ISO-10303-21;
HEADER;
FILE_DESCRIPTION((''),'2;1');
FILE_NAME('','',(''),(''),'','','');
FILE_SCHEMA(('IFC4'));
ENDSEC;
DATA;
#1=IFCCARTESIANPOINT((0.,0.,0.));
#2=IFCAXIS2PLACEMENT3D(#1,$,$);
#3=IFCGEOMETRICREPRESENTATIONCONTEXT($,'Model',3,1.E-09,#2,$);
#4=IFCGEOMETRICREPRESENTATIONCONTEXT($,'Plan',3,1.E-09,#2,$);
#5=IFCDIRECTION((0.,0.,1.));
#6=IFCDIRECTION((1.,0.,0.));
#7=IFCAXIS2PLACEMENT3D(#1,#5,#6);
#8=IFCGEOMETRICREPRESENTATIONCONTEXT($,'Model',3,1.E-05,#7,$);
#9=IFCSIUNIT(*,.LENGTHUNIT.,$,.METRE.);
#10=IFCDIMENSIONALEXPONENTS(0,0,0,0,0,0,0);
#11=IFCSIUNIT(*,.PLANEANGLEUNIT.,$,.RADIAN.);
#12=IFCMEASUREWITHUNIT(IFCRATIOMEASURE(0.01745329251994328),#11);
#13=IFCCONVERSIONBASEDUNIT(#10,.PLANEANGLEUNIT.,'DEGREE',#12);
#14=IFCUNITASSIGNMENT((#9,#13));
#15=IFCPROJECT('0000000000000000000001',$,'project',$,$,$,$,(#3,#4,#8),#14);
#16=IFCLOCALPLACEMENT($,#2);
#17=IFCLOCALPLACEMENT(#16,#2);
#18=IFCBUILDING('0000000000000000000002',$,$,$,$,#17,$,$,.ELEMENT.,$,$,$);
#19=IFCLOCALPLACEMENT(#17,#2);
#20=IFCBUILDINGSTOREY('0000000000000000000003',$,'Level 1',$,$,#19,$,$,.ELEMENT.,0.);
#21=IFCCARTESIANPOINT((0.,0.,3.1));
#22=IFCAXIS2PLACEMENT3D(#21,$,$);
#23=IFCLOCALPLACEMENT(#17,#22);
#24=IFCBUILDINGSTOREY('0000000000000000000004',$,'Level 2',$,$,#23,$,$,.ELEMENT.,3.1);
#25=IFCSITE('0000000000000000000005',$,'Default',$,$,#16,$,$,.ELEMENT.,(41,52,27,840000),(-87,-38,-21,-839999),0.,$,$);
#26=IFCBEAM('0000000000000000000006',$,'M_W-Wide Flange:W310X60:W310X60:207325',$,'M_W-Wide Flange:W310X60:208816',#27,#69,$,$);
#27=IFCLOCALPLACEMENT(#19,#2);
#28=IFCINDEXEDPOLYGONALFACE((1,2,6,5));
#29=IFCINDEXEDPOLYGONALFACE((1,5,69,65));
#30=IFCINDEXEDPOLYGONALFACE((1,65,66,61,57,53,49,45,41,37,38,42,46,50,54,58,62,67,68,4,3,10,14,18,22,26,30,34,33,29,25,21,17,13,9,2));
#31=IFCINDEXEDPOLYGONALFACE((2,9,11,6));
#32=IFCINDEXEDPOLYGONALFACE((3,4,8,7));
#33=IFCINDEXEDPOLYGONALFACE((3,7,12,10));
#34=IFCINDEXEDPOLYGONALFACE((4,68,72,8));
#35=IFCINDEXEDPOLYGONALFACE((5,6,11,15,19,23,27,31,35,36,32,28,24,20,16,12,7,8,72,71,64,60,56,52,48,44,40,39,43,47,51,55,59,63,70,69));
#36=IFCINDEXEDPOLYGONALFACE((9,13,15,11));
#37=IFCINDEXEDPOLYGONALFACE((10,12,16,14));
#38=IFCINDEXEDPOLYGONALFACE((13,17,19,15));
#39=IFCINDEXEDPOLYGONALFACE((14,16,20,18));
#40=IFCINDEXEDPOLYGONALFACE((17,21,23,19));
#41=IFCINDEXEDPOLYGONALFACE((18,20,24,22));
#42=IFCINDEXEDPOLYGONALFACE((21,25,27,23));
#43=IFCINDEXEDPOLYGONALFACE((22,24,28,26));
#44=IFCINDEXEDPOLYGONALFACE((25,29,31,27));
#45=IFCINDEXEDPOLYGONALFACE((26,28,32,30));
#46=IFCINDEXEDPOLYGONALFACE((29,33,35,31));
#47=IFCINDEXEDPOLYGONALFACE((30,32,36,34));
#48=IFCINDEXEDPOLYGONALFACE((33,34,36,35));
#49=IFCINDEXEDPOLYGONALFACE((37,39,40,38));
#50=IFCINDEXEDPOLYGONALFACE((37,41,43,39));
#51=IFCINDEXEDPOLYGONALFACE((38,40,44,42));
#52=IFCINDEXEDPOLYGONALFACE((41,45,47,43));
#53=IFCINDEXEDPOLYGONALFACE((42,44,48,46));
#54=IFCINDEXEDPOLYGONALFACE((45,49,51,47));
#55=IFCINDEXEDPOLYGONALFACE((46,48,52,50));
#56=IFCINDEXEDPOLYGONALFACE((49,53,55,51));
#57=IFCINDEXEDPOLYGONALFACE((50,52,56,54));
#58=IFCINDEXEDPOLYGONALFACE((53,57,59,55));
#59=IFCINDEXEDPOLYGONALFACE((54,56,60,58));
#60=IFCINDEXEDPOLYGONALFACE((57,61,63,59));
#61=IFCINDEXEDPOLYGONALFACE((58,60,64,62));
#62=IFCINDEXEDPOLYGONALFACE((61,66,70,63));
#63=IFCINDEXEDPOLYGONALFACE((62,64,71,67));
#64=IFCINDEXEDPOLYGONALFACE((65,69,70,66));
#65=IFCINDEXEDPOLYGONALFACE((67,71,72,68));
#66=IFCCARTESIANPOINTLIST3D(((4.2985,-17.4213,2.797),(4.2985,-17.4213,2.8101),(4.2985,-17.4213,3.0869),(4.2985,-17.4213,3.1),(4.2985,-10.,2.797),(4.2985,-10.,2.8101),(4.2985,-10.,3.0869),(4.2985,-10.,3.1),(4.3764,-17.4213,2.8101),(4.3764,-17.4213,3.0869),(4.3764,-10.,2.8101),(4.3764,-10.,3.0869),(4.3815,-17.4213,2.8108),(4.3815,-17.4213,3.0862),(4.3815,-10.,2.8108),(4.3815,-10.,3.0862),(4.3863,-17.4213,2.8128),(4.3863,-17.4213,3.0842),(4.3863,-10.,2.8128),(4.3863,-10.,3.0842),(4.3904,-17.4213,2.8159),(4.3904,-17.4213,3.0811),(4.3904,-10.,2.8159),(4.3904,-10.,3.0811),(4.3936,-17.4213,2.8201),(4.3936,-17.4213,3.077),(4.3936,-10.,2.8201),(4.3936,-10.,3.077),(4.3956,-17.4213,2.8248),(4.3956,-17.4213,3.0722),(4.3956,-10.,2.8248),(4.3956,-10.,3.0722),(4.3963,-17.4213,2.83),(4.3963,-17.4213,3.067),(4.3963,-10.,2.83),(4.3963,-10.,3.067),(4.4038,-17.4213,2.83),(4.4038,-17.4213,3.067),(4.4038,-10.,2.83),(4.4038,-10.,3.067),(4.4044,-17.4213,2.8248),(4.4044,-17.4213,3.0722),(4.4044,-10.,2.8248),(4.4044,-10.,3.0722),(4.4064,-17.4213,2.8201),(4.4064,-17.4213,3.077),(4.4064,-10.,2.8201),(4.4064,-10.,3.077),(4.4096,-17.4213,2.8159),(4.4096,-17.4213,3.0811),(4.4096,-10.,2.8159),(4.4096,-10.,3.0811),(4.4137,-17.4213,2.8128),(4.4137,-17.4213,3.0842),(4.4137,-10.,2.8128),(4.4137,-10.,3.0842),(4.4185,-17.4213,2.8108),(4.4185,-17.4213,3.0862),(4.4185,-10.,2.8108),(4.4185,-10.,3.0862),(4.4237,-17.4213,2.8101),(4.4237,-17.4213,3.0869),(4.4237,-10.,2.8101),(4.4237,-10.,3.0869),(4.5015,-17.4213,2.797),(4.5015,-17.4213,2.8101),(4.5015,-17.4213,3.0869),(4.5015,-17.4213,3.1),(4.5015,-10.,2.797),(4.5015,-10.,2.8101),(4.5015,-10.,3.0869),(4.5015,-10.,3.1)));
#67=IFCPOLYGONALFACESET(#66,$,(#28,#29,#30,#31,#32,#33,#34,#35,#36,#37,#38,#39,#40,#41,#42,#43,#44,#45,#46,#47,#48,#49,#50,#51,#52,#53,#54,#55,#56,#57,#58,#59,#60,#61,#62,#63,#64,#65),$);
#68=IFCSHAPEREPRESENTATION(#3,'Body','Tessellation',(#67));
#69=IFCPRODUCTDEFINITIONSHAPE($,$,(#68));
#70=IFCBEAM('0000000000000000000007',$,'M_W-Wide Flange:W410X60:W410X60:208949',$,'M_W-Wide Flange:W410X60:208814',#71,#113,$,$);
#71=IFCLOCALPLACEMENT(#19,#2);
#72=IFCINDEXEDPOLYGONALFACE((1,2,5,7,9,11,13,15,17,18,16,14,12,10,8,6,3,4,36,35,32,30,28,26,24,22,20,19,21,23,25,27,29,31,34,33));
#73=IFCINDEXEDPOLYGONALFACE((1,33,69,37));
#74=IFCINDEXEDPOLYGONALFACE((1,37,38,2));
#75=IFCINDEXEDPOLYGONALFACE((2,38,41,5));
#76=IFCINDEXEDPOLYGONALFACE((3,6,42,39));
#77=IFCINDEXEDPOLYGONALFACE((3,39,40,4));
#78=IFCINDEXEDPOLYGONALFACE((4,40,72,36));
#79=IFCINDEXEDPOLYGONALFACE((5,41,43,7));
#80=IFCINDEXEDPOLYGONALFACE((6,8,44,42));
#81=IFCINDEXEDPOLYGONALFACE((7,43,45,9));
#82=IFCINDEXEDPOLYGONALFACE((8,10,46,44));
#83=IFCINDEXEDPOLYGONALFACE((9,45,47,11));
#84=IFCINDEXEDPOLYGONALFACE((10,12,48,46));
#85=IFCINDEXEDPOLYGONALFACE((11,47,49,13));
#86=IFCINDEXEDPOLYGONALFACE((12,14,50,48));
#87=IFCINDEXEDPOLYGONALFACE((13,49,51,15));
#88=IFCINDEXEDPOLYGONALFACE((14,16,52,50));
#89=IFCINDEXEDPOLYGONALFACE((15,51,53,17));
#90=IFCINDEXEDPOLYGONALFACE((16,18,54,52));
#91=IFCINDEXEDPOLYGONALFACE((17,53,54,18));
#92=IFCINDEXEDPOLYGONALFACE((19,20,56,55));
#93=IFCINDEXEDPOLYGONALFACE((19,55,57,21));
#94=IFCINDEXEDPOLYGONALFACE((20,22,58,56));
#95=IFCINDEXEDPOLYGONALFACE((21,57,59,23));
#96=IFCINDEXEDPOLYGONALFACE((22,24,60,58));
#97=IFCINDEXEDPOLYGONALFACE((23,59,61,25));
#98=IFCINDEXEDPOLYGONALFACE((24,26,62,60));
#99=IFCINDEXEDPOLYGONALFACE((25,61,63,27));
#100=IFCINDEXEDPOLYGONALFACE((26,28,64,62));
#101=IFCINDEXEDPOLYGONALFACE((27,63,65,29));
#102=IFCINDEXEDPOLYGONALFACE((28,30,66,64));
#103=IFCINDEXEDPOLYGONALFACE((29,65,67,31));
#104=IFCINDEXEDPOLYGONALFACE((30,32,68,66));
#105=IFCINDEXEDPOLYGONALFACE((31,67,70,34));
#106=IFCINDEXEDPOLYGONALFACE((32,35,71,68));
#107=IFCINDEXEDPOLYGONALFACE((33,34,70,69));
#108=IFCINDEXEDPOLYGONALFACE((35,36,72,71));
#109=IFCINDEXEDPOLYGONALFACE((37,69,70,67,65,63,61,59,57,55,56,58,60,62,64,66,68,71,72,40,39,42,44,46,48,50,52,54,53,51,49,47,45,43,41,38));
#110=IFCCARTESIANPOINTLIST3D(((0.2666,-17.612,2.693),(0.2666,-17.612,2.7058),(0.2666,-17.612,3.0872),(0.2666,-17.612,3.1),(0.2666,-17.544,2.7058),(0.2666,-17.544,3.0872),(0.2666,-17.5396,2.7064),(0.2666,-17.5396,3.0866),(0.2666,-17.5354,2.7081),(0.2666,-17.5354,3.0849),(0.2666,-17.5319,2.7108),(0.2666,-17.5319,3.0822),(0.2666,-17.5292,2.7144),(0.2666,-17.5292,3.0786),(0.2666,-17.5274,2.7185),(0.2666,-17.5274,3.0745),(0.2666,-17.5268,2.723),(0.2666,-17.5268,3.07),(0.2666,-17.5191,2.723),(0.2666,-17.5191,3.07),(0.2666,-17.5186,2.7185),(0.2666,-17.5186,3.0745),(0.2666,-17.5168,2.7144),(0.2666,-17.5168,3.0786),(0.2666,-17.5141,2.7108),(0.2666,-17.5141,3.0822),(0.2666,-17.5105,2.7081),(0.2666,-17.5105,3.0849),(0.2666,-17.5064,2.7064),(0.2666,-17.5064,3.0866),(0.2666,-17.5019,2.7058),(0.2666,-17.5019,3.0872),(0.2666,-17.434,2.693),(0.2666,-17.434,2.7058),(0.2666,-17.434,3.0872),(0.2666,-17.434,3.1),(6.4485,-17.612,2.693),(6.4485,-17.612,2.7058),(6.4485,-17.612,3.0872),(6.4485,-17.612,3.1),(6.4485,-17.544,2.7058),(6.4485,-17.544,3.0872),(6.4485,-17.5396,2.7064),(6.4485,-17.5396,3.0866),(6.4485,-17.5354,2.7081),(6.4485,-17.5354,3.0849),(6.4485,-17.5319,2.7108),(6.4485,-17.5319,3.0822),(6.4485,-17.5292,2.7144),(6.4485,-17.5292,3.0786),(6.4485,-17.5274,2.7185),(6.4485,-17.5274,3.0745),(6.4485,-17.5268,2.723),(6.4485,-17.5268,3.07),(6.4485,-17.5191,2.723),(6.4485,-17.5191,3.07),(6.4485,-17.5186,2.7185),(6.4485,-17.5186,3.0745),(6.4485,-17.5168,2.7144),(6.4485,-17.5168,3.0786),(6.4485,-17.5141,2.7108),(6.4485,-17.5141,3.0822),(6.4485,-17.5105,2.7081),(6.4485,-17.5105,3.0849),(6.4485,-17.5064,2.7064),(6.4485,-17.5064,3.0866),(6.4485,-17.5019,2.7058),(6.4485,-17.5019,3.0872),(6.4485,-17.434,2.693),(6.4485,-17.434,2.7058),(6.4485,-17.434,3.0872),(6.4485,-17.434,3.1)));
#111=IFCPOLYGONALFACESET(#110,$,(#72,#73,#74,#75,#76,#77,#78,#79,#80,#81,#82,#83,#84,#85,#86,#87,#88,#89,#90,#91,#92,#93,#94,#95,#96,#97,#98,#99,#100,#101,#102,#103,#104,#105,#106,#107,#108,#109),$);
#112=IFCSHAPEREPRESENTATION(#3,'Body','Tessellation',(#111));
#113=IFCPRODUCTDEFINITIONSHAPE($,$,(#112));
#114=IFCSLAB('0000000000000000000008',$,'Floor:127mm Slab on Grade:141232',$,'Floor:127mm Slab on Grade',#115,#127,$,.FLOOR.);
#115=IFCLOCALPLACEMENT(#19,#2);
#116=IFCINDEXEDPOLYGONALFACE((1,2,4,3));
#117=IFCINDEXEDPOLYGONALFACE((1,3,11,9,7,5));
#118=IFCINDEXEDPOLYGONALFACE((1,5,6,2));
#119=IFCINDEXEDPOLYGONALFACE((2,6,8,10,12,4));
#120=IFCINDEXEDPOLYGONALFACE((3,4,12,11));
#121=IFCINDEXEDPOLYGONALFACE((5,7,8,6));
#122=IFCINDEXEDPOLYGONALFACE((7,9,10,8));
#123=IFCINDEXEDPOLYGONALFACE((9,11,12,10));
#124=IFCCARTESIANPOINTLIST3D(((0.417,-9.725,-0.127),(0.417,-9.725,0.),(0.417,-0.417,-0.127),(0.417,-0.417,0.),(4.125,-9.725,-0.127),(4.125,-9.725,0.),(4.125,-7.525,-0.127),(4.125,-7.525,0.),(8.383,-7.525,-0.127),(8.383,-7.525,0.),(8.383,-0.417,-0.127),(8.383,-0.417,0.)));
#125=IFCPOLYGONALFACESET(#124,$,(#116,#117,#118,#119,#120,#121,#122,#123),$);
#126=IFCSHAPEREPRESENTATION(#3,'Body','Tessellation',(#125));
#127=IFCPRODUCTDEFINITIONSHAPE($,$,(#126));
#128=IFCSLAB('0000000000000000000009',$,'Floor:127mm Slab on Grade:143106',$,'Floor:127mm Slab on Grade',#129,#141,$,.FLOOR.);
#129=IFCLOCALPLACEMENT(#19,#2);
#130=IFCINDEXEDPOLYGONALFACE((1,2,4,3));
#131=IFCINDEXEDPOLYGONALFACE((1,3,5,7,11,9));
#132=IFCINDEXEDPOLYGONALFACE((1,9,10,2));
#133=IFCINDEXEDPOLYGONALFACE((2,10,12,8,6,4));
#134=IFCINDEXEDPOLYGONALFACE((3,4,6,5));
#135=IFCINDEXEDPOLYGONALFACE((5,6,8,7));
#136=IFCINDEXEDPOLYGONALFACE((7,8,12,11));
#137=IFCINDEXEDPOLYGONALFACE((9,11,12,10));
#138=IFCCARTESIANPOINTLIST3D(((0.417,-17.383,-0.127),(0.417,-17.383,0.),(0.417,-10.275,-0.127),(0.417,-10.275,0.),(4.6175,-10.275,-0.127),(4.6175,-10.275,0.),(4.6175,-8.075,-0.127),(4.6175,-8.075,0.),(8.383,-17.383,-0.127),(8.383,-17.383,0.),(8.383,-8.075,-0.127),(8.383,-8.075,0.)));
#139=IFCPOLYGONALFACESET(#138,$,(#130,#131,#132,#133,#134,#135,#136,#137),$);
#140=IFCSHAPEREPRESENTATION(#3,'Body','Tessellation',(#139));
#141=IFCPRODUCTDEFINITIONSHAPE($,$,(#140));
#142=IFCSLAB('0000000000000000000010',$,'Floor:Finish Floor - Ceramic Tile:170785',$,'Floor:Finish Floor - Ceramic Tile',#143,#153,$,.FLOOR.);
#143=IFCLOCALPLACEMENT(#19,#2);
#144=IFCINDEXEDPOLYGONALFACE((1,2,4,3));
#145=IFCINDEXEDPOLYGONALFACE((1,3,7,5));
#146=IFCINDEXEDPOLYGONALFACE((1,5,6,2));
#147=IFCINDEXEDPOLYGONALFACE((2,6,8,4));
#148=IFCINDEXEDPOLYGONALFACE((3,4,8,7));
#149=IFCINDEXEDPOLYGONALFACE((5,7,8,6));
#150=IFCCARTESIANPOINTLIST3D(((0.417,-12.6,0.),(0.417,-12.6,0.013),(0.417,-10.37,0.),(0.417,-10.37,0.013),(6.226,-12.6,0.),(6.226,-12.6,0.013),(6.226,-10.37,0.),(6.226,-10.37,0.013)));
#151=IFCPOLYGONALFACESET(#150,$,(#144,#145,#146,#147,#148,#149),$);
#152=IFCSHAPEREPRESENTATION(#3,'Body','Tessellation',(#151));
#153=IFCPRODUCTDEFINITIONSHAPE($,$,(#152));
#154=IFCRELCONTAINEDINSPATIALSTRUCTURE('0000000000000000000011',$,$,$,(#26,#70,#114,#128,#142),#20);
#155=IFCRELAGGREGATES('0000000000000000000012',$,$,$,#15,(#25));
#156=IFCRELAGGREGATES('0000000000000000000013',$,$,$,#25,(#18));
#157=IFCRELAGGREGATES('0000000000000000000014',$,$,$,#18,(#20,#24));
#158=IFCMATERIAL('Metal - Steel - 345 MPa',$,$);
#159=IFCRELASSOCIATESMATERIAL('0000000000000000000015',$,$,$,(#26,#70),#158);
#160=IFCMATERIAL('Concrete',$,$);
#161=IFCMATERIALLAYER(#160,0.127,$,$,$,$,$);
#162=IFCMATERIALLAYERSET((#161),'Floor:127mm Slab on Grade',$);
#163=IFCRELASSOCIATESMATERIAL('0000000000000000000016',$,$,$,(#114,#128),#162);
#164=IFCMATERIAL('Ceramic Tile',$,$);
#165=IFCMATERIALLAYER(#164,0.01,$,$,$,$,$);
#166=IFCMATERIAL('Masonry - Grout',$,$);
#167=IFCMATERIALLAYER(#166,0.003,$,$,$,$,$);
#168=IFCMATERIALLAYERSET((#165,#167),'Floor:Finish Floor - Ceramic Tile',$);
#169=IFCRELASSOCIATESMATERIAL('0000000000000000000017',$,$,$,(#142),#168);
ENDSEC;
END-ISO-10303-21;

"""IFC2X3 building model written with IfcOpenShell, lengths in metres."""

from ifc_helpers import new_model, entity, si_unit, converted_unit, frame, frame_2d, origin, origin_with_axes, place, context, project, spatial, polyline, circle_curve, parameter, trimmed, segment, composite_curve, rectangle, outline, extrude, material, layer, layer_set, layer_usage, element, save


model = new_model("IFC2X3")

# Units and contexts
model_context_1 = context("Model", 3, precision=1e-09, world=origin())
plan_context = context("Plan", 3, precision=1e-09, world=origin())
model_context_2 = context("Model", 3, precision=1e-05, world=origin_with_axes())
ifc_project = project(units=[si_unit("LENGTHUNIT", "METRE"), converted_unit("PLANEANGLEUNIT", "DEGREE", entity("IfcRatioMeasure", 0.01745329251994328), si_unit("PLANEANGLEUNIT", "RADIAN"), dimensions=[0, 0, 0, 0, 0, 0, 0])], contexts=[model_context_1, plan_context, model_context_2])

# Site, building, storey
site_placement = place(None, origin())
site = spatial("IfcSite", under=ifc_project, at=site_placement, Name="Default", CompositionType="ELEMENT", RefLatitude=(41, 52, 27, 840000), RefLongitude=(-87, -38, -21, -839999), RefElevation=0.0)
building_placement = place(site_placement, origin())
building = spatial("IfcBuilding", under=site, at=building_placement, CompositionType="ELEMENT")
storey_1_placement = place(building_placement, origin())
storey_1 = spatial("IfcBuildingStorey", under=building, at=storey_1_placement, Name="Level 1", CompositionType="ELEMENT", Elevation=0.0)

# Beams
ifc_material_1 = material(Name="Metal - Steel - 345 MPa")
beam_1_placement = place(storey_1_placement, frame((4.4, -10.0, 3.1), z_axis=(0.0, 0.0, 1.0), x_axis=(-1.0, 0.0, 0.0)))
element("IfcBeam", 1, at=beam_1_placement, inside=storey_1, material=ifc_material_1, Name="M_W-Wide Flange:W310X60:W310X60:207325", ObjectType="M_W-Wide Flange:W310X60:208816", context=model_context_1, shape_type="SweptSolid", body=[
    extrude(outline(composite_curve([segment(polyline([(0.1384, -0.1015), (0.1515, -0.1015)]), True, "CONTINUOUS"), segment(polyline([(0.1515, -0.1015), (0.1515, 0.1015)]), True, "CONTINUOUS"), segment(polyline([(0.1515, 0.1015), (0.1384, 0.1015)]), True, "CONTINUOUS"), segment(polyline([(0.1384, 0.1015), (0.1384, 0.0236)]), True, "CONTINUOUS"), segment(trimmed(circle_curve(frame_2d((0.1185, 0.0236), x_axis=(0.0, 1.0)), 0.0199), [parameter(180.0)], [parameter(270.0)], True, "PARAMETER"), False, "CONTINUOUS"), segment(polyline([(0.1185, 0.0037), (-0.1185, 0.0037)]), True, "CONTINUOUS"), segment(trimmed(circle_curve(frame_2d((-0.1185, 0.0236), x_axis=(0.0, 1.0)), 0.0199), [parameter(90.0)], [parameter(180.0)], True, "PARAMETER"), False, "CONTINUOUS"), segment(polyline([(-0.1384, 0.0236), (-0.1384, 0.1015)]), True, "CONTINUOUS"), segment(polyline([(-0.1384, 0.1015), (-0.1515, 0.1015)]), True, "CONTINUOUS"), segment(polyline([(-0.1515, 0.1015), (-0.1515, -0.1015)]), True, "CONTINUOUS"), segment(polyline([(-0.1515, -0.1015), (-0.1384, -0.1015)]), True, "CONTINUOUS"), segment(polyline([(-0.1384, -0.1015), (-0.1384, -0.0237)]), True, "CONTINUOUS"), segment(trimmed(circle_curve(frame_2d((-0.1185, -0.0237), x_axis=(0.0, 1.0)), 0.0199), [parameter(360.0)], [parameter(90.0)], True, "PARAMETER"), False, "CONTINUOUS"), segment(polyline([(-0.1185, -0.0038), (0.1185, -0.0038)]), True, "CONTINUOUS"), segment(trimmed(circle_curve(frame_2d((0.1185, -0.0237), x_axis=(0.0, 1.0)), 0.0199), [parameter(270.0)], [parameter(0.0)], True, "PARAMETER"), False, "CONTINUOUS"), segment(polyline([(0.1384, -0.0237), (0.1384, -0.1015)]), True, "CONTINUOUS")], self_intersect=False)), frame((0.0, 7.4213, -0.1515), z_axis=(0.0, -1.0, 0.0), x_axis=(0.0, 0.0, -1.0)), (0.0, 0.0, 1.0), 7.4213),
])
beam_2_placement = place(storey_1_placement, frame((0.2085, -17.523, 3.1), z_axis=(0.0, 0.0, 1.0), x_axis=(0.0, -1.0, 0.0)))
element("IfcBeam", 2, at=beam_2_placement, inside=storey_1, material=ifc_material_1, Name="M_W-Wide Flange:W410X60:W410X60:208949", ObjectType="M_W-Wide Flange:W410X60:208814", context=model_context_1, shape_type="SweptSolid", body=[
    extrude(outline(composite_curve([segment(polyline([(-0.089, -0.1907), (-0.089, -0.2035)]), True, "CONTINUOUS"), segment(polyline([(-0.089, -0.2035), (0.089, -0.2035)]), True, "CONTINUOUS"), segment(polyline([(0.089, -0.2035), (0.089, -0.1907)]), True, "CONTINUOUS"), segment(polyline([(0.089, -0.1907), (0.021, -0.1907)]), True, "CONTINUOUS"), segment(trimmed(circle_curve(frame_2d((0.021, -0.1735), x_axis=(0.0, -1.0)), 0.0172), [parameter(270.0)], [parameter(360.0)], True, "PARAMETER"), False, "CONTINUOUS"), segment(polyline([(0.0038, -0.1735), (0.0038, 0.1735)]), True, "CONTINUOUS"), segment(trimmed(circle_curve(frame_2d((0.021, 0.1735), x_axis=(-1.0, 0.0)), 0.0172), [parameter(270.0)], [parameter(360.0)], True, "PARAMETER"), False, "CONTINUOUS"), segment(polyline([(0.021, 0.1907), (0.089, 0.1907)]), True, "CONTINUOUS"), segment(polyline([(0.089, 0.1907), (0.089, 0.2035)]), True, "CONTINUOUS"), segment(polyline([(0.089, 0.2035), (-0.089, 0.2035)]), True, "CONTINUOUS"), segment(polyline([(-0.089, 0.2035), (-0.089, 0.1907)]), True, "CONTINUOUS"), segment(polyline([(-0.089, 0.1907), (-0.0211, 0.1907)]), True, "CONTINUOUS"), segment(trimmed(circle_curve(frame_2d((-0.0211, 0.1735), x_axis=(0.0, 1.0)), 0.0172), [parameter(270.0)], [parameter(0.0)], True, "PARAMETER"), False, "CONTINUOUS"), segment(polyline([(-0.0039, 0.1735), (-0.0039, -0.1735)]), True, "CONTINUOUS"), segment(trimmed(circle_curve(frame_2d((-0.0211, -0.1735), x_axis=(1.0, 0.0)), 0.0172), [parameter(270.0)], [parameter(0.0)], True, "PARAMETER"), False, "CONTINUOUS"), segment(polyline([(-0.0211, -0.1907), (-0.089, -0.1907)]), True, "CONTINUOUS")], self_intersect=False)), frame((0.0, 0.0581, -0.2035), z_axis=(0.0, -1.0, 0.0), x_axis=(1.0, 0.0, 0.0)), (0.0, 0.0, -1.0), 6.1819),
])

# Slabs
ifc_material_2 = material(Name="Concrete")
ifc_layer_1 = layer(ifc_material_2, 0.127)
ifc_layer_set_1 = layer_set([ifc_layer_1], Name="Floor:127mm Slab on Grade")
ifc_layer_usage_1 = layer_usage(ifc_layer_set_1, "AXIS3", "POSITIVE", 0.0)
slab_1_placement = place(storey_1_placement, frame((0.417, -9.725, -0.127)))
element("IfcSlab", 3, at=slab_1_placement, inside=storey_1, material=ifc_layer_usage_1, Name="Floor:127mm Slab on Grade:141232", ObjectType="Floor:127mm Slab on Grade", PredefinedType="FLOOR", context=model_context_1, shape_type="SweptSolid", body=[
    extrude(outline(polyline([(-3.983, 4.654), (-3.983, -2.454), (0.275, -2.454), (0.275, -4.654), (3.983, -4.654), (3.983, 4.654), (-3.983, 4.654)])), frame((3.983, 4.654, 0.127), z_axis=(0.0, 0.0, -1.0), x_axis=(-1.0, 0.0, 0.0)), (0.0, 0.0, 1.0), 0.127),
])
ifc_layer_usage_2 = layer_usage(ifc_layer_set_1, "AXIS3", "POSITIVE", 0.0)
slab_2_placement = place(storey_1_placement, frame((0.417, -17.383, -0.127)))
element("IfcSlab", 4, at=slab_2_placement, inside=storey_1, material=ifc_layer_usage_2, Name="Floor:127mm Slab on Grade:143106", ObjectType="Floor:127mm Slab on Grade", PredefinedType="FLOOR", context=model_context_1, shape_type="SweptSolid", body=[
    extrude(outline(polyline([(-3.983, 4.654), (-3.983, -4.654), (3.983, -4.654), (3.983, 2.454), (-0.2175, 2.454), (-0.2175, 4.654), (-3.983, 4.654)])), frame((3.983, 4.654, 0.127), z_axis=(0.0, 0.0, -1.0), x_axis=(-1.0, 0.0, 0.0)), (0.0, 0.0, 1.0), 0.127),
])
ifc_material_3 = material(Name="Ceramic Tile")
ifc_layer_2 = layer(ifc_material_3, 0.01)
ifc_material_4 = material(Name="Masonry - Grout")
ifc_layer_3 = layer(ifc_material_4, 0.003)
ifc_layer_set_2 = layer_set([ifc_layer_2, ifc_layer_3], Name="Floor:Finish Floor - Ceramic Tile")
ifc_layer_usage_3 = layer_usage(ifc_layer_set_2, "AXIS3", "POSITIVE", 0.0)
slab_3_placement = place(storey_1_placement, frame((0.417, -12.6, 0.0)))
element("IfcSlab", 5, at=slab_3_placement, inside=storey_1, material=ifc_layer_usage_3, Name="Floor:Finish Floor - Ceramic Tile:170785", ObjectType="Floor:Finish Floor - Ceramic Tile", PredefinedType="FLOOR", context=model_context_1, shape_type="SweptSolid", body=[
    extrude(rectangle(XDim=5.809, YDim=2.23, at=frame_2d((0.0, 0.0), x_axis=(-1.0, 0.0))), frame((2.9045, 1.115, 0.013), z_axis=(0.0, 0.0, -1.0), x_axis=(-1.0, 0.0, 0.0)), (0.0, 0.0, 1.0), 0.013),
])

# Shared definitions
storey_2_placement = place(building_placement, frame((0.0, 0.0, 3.1)))
storey_2 = spatial("IfcBuildingStorey", under=building, at=storey_2_placement, Name="Level 2", CompositionType="ELEMENT", Elevation=3.1)

save(model, "model.ifc")
